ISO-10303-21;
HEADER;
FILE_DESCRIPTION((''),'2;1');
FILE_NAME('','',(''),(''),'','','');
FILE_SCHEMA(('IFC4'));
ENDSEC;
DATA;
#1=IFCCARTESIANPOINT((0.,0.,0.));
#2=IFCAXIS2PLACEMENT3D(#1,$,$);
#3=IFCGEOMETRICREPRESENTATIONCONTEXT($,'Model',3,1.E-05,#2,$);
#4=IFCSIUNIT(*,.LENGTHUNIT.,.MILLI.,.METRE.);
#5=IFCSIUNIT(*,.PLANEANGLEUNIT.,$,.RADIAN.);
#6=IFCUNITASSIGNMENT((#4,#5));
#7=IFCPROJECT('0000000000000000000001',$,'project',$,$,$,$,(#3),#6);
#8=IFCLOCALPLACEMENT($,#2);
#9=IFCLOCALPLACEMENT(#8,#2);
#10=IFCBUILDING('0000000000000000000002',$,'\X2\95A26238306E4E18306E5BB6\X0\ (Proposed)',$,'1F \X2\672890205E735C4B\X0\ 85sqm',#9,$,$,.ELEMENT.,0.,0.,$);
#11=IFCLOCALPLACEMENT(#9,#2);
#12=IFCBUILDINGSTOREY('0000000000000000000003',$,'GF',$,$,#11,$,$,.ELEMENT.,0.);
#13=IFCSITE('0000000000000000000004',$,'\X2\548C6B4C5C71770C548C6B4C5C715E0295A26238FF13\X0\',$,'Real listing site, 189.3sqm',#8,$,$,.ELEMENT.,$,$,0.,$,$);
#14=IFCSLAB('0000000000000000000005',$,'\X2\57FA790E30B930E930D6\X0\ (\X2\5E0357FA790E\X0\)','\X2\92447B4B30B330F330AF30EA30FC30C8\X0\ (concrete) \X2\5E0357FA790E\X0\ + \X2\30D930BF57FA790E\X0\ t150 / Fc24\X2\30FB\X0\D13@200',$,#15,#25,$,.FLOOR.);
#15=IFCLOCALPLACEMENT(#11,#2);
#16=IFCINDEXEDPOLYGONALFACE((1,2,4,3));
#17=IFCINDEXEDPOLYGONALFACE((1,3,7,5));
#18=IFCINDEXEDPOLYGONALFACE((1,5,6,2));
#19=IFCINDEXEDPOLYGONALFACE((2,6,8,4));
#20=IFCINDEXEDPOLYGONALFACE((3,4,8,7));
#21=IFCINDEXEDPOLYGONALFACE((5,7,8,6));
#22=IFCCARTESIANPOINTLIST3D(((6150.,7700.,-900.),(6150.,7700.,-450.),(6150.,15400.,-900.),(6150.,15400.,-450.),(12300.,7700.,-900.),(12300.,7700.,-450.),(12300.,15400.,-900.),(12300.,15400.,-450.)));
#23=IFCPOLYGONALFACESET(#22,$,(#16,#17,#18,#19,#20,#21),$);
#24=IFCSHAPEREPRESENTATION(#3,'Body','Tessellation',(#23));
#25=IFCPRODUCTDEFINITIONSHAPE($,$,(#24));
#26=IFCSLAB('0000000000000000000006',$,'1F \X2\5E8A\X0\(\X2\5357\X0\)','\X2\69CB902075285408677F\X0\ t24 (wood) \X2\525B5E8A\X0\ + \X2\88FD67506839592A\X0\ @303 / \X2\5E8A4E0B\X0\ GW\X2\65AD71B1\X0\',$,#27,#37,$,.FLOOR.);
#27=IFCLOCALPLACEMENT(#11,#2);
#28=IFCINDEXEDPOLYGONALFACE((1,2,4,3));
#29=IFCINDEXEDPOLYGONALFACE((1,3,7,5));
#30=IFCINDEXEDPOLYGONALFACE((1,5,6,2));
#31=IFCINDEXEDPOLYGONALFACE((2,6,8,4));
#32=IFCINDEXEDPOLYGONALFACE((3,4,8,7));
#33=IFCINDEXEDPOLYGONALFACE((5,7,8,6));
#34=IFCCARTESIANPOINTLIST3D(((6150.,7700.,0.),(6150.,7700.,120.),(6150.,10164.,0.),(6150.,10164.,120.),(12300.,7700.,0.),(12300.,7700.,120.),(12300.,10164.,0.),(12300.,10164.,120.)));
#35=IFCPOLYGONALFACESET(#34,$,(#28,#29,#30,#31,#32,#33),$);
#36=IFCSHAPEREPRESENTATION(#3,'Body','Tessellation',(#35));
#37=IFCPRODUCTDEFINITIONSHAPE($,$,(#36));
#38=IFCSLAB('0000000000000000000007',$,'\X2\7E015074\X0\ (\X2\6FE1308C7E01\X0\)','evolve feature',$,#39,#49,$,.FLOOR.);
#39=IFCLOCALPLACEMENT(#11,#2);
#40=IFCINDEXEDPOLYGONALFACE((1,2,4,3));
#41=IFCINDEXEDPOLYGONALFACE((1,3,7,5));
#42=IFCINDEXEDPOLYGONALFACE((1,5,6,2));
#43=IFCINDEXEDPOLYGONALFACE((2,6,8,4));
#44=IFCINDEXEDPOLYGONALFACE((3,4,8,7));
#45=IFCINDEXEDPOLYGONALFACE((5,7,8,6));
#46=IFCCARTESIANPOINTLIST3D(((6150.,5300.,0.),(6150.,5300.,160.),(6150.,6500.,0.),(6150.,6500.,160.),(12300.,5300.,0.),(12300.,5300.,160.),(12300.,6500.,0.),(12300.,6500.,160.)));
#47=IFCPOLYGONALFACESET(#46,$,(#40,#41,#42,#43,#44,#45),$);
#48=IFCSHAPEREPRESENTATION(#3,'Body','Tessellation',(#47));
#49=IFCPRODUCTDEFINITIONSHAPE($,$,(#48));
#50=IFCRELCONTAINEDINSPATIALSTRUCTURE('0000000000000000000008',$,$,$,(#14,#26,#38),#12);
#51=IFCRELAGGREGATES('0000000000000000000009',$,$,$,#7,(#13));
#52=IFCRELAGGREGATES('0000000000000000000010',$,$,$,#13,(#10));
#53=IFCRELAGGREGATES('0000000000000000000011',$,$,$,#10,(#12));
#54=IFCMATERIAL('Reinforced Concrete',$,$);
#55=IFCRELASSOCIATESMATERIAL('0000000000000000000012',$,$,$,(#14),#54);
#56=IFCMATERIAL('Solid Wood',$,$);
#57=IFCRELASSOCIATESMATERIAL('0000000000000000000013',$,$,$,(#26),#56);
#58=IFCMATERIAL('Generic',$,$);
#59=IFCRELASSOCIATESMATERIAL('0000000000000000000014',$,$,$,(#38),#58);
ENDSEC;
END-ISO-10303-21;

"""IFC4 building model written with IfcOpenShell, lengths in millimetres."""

from ifc_helpers import new_model, si_unit, frame, frame_2d, origin, place, context, project, spatial, rectangle, extrude, material, element, save


model = new_model("IFC4")

# Units and contexts
model_context = context("Model", 3, precision=1e-05, world=origin())
ifc_project = project(units=[si_unit("LENGTHUNIT", "METRE", prefix="MILLI"), si_unit("PLANEANGLEUNIT", "RADIAN")], contexts=[model_context])

# Site, building, storey
site_placement = place(None, origin())
site = spatial("IfcSite", under=ifc_project, at=site_placement, Name="和歌山県和歌山市関戸３", ObjectType="Real listing site, 189.3sqm", CompositionType="ELEMENT", RefElevation=0.0)
building_placement = place(site_placement, origin())
building = spatial("IfcBuilding", under=site, at=building_placement, Name="関戸の丘の家 (Proposed)", ObjectType="1F 木造平屋 85sqm", CompositionType="ELEMENT", ElevationOfRefHeight=0.0, ElevationOfTerrain=0.0)
storey_placement = place(building_placement, origin())
storey = spatial("IfcBuildingStorey", under=building, at=storey_placement, Name="GF", CompositionType="ELEMENT", Elevation=0.0)

# Slabs
ifc_material_1 = material(Name="Reinforced Concrete")
slab_1_placement = place(storey_placement, frame((3075.0, 3850.0, -450.0)))
element("IfcSlab", 1, at=slab_1_placement, inside=storey, material=ifc_material_1, Name="基礎スラブ (布基礎)", Description="鉄筋コンクリート (concrete) 布基礎 + ベタ基礎 t150 / Fc24・D13@200", PredefinedType="FLOOR", context=model_context, shape_type="SweptSolid", body=[
    extrude(rectangle(XDim=6150.0, YDim=7700.0, at=frame_2d((3075.0, 3850.0))), frame((3075.0, 3850.0, -450.0)), (0.0, 0.0, 1.0), 450.0),
])
ifc_material_2 = material(Name="Solid Wood")
slab_2_placement = place(storey_placement, frame((3075.0, 3850.0, 0.0)))
element("IfcSlab", 2, at=slab_2_placement, inside=storey, material=ifc_material_2, Name="1F 床(南)", Description="構造用合板 t24 (wood) 剛床 + 製材根太 @303 / 床下 GW断熱", PredefinedType="FLOOR", context=model_context, shape_type="SweptSolid", body=[
    extrude(rectangle(XDim=6150.0, YDim=2464.0, at=frame_2d((3075.0, 1232.0))), frame((3075.0, 3850.0, 0.0)), (0.0, 0.0, 1.0), 120.0),
])
ifc_material_3 = material(Name="Generic")
slab_3_placement = place(storey_placement, frame((3075.0, 2650.0, 0.0)))
element("IfcSlab", 3, at=slab_3_placement, inside=storey, material=ifc_material_3, Name="縁側 (濡れ縁)", Description="evolve feature", PredefinedType="FLOOR", context=model_context, shape_type="SweptSolid", body=[
    extrude(rectangle(XDim=6150.0, YDim=1200.0, at=frame_2d((3075.0, 600.0))), frame((3075.0, 2650.0, 0.0)), (0.0, 0.0, 1.0), 160.0),
])

save(model, "model.ifc")
